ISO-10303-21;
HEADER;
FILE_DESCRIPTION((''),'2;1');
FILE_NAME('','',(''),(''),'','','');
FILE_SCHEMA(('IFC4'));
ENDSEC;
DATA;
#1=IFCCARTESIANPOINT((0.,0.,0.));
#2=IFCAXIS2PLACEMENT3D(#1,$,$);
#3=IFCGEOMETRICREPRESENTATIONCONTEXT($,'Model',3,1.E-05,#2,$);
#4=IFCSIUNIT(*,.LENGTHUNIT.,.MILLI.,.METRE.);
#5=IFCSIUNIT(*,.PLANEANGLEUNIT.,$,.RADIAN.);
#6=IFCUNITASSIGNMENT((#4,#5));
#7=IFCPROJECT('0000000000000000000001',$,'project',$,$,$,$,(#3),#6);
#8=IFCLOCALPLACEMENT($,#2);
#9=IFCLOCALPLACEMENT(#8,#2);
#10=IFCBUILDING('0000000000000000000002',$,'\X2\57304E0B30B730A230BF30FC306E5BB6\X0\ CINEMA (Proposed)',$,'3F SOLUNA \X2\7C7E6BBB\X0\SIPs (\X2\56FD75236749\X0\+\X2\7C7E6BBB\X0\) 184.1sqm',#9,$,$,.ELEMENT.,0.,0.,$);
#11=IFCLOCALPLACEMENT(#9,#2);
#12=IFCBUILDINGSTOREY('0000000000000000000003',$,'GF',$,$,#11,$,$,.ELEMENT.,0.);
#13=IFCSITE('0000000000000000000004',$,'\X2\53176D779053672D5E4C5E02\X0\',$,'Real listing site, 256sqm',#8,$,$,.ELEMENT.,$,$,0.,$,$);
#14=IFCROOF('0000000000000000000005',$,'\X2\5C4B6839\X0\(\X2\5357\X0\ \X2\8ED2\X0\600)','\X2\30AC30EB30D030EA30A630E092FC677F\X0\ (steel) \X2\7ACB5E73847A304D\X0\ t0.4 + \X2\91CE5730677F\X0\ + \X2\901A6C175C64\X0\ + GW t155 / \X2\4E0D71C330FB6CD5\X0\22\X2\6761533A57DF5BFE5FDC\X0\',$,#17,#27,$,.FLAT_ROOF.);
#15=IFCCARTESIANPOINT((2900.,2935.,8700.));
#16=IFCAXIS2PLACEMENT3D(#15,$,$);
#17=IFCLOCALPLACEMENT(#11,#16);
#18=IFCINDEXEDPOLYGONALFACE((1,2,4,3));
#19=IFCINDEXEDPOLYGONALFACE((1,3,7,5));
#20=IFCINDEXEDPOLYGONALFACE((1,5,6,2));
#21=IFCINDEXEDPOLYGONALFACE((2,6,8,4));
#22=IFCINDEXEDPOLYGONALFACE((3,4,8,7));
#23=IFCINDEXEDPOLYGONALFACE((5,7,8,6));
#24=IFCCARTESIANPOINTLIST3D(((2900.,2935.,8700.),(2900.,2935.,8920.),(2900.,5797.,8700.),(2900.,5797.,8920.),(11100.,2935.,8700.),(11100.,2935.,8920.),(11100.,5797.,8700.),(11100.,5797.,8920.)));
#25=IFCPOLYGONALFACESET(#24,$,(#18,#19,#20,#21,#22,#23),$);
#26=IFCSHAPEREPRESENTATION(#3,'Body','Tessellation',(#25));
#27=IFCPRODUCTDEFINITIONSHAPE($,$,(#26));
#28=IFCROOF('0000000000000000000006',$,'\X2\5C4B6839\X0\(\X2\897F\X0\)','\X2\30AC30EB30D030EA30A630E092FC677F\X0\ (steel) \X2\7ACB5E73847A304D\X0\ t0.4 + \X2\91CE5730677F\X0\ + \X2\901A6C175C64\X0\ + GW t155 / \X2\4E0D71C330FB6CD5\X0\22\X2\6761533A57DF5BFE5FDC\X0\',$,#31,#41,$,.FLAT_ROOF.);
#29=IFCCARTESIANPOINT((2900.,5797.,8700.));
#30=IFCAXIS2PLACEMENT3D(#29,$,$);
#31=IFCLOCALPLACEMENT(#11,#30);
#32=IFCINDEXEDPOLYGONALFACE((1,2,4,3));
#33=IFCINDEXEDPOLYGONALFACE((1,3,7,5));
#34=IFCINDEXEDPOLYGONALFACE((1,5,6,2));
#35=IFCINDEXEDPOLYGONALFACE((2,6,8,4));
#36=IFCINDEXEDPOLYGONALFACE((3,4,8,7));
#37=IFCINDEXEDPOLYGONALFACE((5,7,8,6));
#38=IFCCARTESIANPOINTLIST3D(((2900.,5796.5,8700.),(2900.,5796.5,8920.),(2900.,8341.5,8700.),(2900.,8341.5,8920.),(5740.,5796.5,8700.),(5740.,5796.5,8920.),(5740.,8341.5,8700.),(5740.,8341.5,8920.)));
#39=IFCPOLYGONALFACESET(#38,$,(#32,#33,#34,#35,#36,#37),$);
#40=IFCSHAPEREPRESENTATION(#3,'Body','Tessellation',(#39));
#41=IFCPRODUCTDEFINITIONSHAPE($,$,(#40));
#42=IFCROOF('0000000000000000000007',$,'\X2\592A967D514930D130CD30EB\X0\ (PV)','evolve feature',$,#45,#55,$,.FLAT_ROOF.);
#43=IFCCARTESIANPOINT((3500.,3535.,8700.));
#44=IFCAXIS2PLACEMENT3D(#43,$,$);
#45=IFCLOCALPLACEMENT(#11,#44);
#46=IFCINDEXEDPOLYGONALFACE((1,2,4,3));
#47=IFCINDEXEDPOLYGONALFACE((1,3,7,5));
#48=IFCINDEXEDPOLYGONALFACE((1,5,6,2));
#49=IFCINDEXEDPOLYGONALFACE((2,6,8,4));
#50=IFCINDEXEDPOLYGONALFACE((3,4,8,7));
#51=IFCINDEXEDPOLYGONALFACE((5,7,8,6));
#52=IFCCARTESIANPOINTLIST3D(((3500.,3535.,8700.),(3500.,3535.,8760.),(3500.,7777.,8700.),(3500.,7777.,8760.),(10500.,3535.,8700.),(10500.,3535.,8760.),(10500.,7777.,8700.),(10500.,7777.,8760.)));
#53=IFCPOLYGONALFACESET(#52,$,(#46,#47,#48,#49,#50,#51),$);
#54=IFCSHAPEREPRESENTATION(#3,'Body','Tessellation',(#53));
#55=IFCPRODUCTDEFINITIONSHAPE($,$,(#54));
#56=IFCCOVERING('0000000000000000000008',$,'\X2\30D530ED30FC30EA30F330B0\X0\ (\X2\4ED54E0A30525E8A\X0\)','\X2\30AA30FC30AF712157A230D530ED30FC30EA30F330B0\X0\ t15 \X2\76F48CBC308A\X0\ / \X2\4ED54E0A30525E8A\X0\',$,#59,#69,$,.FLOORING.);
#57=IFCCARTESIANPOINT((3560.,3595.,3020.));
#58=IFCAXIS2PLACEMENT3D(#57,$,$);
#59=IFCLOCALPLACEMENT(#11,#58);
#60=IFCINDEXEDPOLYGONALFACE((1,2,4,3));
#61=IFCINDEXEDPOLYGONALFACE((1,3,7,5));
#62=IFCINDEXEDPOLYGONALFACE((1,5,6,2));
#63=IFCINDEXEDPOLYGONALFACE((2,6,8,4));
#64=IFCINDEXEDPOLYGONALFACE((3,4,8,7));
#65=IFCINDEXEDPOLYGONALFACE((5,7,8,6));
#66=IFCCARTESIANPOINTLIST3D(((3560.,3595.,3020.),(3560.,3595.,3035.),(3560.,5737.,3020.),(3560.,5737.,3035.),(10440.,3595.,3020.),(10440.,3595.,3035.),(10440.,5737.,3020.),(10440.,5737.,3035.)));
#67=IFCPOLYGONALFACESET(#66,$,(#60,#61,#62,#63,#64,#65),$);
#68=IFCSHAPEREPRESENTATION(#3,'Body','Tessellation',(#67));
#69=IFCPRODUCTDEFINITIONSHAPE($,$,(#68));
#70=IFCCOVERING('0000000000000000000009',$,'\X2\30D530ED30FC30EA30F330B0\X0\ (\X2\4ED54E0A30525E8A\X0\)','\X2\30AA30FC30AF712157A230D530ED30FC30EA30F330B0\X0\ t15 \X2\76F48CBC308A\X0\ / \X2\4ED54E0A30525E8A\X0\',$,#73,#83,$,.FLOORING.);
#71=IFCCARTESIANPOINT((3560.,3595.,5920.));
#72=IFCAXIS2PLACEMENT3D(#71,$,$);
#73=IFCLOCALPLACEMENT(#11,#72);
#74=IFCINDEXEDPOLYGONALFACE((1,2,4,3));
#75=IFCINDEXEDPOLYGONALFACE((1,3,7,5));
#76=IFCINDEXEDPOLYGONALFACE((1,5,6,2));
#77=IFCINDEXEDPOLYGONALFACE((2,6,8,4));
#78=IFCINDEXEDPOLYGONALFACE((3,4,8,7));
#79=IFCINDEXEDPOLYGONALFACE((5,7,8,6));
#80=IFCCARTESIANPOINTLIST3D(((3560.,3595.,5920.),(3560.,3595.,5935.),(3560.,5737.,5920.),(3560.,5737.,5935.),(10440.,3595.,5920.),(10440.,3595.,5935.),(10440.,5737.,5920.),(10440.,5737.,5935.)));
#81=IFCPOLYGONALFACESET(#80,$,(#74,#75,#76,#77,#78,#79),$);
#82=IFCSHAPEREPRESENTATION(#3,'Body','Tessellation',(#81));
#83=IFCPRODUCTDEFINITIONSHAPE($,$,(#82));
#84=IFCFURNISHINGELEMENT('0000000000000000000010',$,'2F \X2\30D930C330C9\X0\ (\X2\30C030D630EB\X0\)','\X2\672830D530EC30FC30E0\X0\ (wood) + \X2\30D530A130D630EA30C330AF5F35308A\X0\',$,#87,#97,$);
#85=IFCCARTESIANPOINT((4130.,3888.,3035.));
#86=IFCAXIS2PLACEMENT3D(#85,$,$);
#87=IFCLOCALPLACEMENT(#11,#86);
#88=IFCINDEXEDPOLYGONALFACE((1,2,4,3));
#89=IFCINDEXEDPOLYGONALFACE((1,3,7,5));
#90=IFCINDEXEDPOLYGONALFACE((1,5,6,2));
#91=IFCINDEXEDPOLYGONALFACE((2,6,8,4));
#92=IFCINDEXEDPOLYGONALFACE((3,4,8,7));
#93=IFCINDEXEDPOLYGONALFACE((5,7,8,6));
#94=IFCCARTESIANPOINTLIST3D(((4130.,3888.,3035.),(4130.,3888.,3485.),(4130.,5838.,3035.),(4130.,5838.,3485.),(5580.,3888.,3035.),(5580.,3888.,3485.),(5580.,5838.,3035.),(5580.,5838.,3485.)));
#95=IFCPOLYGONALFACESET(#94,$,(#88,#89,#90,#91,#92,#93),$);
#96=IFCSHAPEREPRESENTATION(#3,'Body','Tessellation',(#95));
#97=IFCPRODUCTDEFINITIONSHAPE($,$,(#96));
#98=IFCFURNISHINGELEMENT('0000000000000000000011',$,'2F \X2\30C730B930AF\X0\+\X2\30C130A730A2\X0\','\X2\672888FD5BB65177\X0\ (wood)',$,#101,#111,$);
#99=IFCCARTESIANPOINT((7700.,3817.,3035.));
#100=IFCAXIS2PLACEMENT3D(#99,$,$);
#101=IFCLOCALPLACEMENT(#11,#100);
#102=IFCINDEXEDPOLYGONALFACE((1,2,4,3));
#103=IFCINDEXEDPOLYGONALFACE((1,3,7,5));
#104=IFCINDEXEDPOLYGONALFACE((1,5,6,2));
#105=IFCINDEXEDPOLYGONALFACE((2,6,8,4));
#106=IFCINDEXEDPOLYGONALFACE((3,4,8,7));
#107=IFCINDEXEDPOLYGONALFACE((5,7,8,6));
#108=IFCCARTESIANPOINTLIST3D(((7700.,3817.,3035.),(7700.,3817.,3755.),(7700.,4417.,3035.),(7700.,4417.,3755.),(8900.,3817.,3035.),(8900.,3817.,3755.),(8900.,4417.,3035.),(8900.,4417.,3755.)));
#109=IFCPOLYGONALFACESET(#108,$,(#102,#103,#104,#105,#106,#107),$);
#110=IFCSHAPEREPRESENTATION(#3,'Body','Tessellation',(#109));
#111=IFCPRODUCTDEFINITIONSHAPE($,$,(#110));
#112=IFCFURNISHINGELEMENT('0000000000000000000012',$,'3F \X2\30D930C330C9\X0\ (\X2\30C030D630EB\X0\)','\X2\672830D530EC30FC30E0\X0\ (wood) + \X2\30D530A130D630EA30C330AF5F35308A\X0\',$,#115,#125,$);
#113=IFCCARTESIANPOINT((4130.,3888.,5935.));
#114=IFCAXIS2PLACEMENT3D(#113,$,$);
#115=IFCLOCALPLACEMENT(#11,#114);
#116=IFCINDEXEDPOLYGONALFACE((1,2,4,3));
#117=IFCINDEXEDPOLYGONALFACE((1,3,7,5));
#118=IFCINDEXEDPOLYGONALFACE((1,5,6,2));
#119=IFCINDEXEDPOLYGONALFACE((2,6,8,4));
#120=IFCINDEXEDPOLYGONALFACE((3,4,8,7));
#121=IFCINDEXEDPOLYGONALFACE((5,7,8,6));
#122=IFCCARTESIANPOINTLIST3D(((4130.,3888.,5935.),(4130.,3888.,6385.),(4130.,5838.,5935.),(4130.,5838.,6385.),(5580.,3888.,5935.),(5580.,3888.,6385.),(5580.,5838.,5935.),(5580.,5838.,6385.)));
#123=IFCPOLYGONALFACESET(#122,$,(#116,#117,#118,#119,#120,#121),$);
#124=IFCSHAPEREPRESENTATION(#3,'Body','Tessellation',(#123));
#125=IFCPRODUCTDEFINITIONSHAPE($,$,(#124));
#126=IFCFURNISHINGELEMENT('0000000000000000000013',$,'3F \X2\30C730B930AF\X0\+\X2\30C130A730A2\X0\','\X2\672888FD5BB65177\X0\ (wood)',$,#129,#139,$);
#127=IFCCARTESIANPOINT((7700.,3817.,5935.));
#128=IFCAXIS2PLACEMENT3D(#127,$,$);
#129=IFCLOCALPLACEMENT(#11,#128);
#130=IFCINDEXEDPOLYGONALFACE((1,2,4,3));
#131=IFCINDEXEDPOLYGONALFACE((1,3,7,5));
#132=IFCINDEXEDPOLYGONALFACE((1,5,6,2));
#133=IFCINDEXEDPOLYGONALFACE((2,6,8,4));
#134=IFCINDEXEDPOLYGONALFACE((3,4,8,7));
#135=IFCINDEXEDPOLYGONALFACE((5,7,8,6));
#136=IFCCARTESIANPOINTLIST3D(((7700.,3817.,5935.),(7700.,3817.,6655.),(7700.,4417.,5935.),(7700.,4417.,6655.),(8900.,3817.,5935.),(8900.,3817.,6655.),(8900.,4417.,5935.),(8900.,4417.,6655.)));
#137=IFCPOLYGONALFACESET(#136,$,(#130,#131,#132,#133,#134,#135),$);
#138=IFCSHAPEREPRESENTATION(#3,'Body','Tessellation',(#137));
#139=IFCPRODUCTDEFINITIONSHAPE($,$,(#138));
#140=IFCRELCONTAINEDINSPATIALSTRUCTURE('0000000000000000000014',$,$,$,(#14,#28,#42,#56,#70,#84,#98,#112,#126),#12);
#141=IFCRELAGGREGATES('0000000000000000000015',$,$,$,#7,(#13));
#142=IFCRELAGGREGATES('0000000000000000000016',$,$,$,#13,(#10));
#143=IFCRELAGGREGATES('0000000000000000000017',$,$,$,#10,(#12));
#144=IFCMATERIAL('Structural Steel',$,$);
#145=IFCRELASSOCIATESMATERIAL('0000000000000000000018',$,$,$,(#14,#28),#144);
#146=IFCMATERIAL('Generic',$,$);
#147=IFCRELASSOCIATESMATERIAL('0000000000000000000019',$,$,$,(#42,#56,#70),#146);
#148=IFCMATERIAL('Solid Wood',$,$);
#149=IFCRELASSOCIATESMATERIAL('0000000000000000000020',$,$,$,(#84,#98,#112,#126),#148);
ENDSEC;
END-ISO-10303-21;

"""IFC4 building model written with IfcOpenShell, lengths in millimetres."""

from ifc_helpers import new_model, si_unit, frame, frame_2d, origin, place, context, project, spatial, rectangle, extrude, material, element, save


model = new_model("IFC4")

# Units and contexts
model_context = context("Model", 3, precision=1e-05, world=origin())
ifc_project = project(units=[si_unit("LENGTHUNIT", "METRE", prefix="MILLI"), si_unit("PLANEANGLEUNIT", "RADIAN")], contexts=[model_context])

# Site, building, storey
site_placement = place(None, origin())
site = spatial("IfcSite", under=ifc_project, at=site_placement, Name="北海道札幌市", ObjectType="Real listing site, 256sqm", CompositionType="ELEMENT", RefElevation=0.0)
building_placement = place(site_placement, origin())
building = spatial("IfcBuilding", under=site, at=building_placement, Name="地下シアターの家 CINEMA (Proposed)", ObjectType="3F SOLUNA 籾殻SIPs (国産杉+籾殻) 184.1sqm", CompositionType="ELEMENT", ElevationOfRefHeight=0.0, ElevationOfTerrain=0.0)
storey_placement = place(building_placement, origin())
storey = spatial("IfcBuildingStorey", under=building, at=storey_placement, Name="GF", CompositionType="ELEMENT", Elevation=0.0)

# Shared definitions
ifc_material_1 = material(Name="Solid Wood")

# Roofs
ifc_material_2 = material(Name="Structural Steel")
roof_1_placement = place(storey_placement, frame((2900.0, 2935.0, 8700.0)))
element("IfcRoof", 1, at=roof_1_placement, inside=storey, material=ifc_material_2, Name="屋根(南 軒600)", Description="ガルバリウム鋼板 (steel) 立平葺き t0.4 + 野地板 + 通気層 + GW t155 / 不燃・法22条区域対応", PredefinedType="FLAT_ROOF", context=model_context, shape_type="SweptSolid", body=[
    extrude(rectangle(XDim=8200.0, YDim=2862.0, at=frame_2d((4100.0, 1431.0))), frame((2900.0, 2935.0, 8700.0)), (0.0, 0.0, 1.0), 220.0),
])
roof_2_placement = place(storey_placement, frame((2900.0, 5797.0, 8700.0)))
element("IfcRoof", 2, at=roof_2_placement, inside=storey, material=ifc_material_2, Name="屋根(西)", Description="ガルバリウム鋼板 (steel) 立平葺き t0.4 + 野地板 + 通気層 + GW t155 / 不燃・法22条区域対応", PredefinedType="FLAT_ROOF", context=model_context, shape_type="SweptSolid", body=[
    extrude(rectangle(XDim=2840.0, YDim=2545.0, at=frame_2d((1420.0, 1272.0))), frame((2900.0, 5797.0, 8700.0)), (0.0, 0.0, 1.0), 220.0),
])
ifc_material_3 = material(Name="Generic")
roof_3_placement = place(storey_placement, frame((3500.0, 3535.0, 8700.0)))
element("IfcRoof", 3, at=roof_3_placement, inside=storey, material=ifc_material_3, Name="太陽光パネル (PV)", Description="evolve feature", PredefinedType="FLAT_ROOF", context=model_context, shape_type="SweptSolid", body=[
    extrude(rectangle(XDim=7000.0, YDim=4242.0, at=frame_2d((3500.0, 2121.0))), frame((3500.0, 3535.0, 8700.0)), (0.0, 0.0, 1.0), 60.0),
])

# Coverings
covering_1_placement = place(storey_placement, frame((3560.0, 3595.0, 3020.0)))
element("IfcCovering", 4, at=covering_1_placement, inside=storey, material=ifc_material_3, Name="フローリング (仕上げ床)", Description="オーク無垢フローリング t15 直貼り / 仕上げ床", PredefinedType="FLOORING", context=model_context, shape_type="SweptSolid", body=[
    extrude(rectangle(XDim=6880.0, YDim=2142.0, at=frame_2d((3440.0, 1071.0))), frame((3560.0, 3595.0, 3020.0)), (0.0, 0.0, 1.0), 15.0),
])
covering_2_placement = place(storey_placement, frame((3560.0, 3595.0, 5920.0)))
element("IfcCovering", 5, at=covering_2_placement, inside=storey, material=ifc_material_3, Name="フローリング (仕上げ床)", Description="オーク無垢フローリング t15 直貼り / 仕上げ床", PredefinedType="FLOORING", context=model_context, shape_type="SweptSolid", body=[
    extrude(rectangle(XDim=6880.0, YDim=2142.0, at=frame_2d((3440.0, 1071.0))), frame((3560.0, 3595.0, 5920.0)), (0.0, 0.0, 1.0), 15.0),
])

# Furnishing elements
furnishing_1_placement = place(storey_placement, frame((4130.0, 3888.0, 3035.0)))
element("IfcFurnishingElement", 6, at=furnishing_1_placement, inside=storey, material=ifc_material_1, Name="2F ベッド (ダブル)", Description="木フレーム (wood) + ファブリック張り", context=model_context, shape_type="SweptSolid", body=[
    extrude(rectangle(XDim=1450.0, YDim=1950.0, at=frame_2d((725.0, 975.0))), frame((4130.0, 3888.0, 3035.0)), (0.0, 0.0, 1.0), 450.0),
])
furnishing_2_placement = place(storey_placement, frame((7700.0, 3817.0, 3035.0)))
element("IfcFurnishingElement", 7, at=furnishing_2_placement, inside=storey, material=ifc_material_1, Name="2F デスク+チェア", Description="木製家具 (wood)", context=model_context, shape_type="SweptSolid", body=[
    extrude(rectangle(XDim=1200.0, YDim=600.0, at=frame_2d((600.0, 300.0))), frame((7700.0, 3817.0, 3035.0)), (0.0, 0.0, 1.0), 720.0),
])
furnishing_3_placement = place(storey_placement, frame((4130.0, 3888.0, 5935.0)))
element("IfcFurnishingElement", 8, at=furnishing_3_placement, inside=storey, material=ifc_material_1, Name="3F ベッド (ダブル)", Description="木フレーム (wood) + ファブリック張り", context=model_context, shape_type="SweptSolid", body=[
    extrude(rectangle(XDim=1450.0, YDim=1950.0, at=frame_2d((725.0, 975.0))), frame((4130.0, 3888.0, 5935.0)), (0.0, 0.0, 1.0), 450.0),
])
furnishing_4_placement = place(storey_placement, frame((7700.0, 3817.0, 5935.0)))
element("IfcFurnishingElement", 9, at=furnishing_4_placement, inside=storey, material=ifc_material_1, Name="3F デスク+チェア", Description="木製家具 (wood)", context=model_context, shape_type="SweptSolid", body=[
    extrude(rectangle(XDim=1200.0, YDim=600.0, at=frame_2d((600.0, 300.0))), frame((7700.0, 3817.0, 5935.0)), (0.0, 0.0, 1.0), 720.0),
])

save(model, "model.ifc")
